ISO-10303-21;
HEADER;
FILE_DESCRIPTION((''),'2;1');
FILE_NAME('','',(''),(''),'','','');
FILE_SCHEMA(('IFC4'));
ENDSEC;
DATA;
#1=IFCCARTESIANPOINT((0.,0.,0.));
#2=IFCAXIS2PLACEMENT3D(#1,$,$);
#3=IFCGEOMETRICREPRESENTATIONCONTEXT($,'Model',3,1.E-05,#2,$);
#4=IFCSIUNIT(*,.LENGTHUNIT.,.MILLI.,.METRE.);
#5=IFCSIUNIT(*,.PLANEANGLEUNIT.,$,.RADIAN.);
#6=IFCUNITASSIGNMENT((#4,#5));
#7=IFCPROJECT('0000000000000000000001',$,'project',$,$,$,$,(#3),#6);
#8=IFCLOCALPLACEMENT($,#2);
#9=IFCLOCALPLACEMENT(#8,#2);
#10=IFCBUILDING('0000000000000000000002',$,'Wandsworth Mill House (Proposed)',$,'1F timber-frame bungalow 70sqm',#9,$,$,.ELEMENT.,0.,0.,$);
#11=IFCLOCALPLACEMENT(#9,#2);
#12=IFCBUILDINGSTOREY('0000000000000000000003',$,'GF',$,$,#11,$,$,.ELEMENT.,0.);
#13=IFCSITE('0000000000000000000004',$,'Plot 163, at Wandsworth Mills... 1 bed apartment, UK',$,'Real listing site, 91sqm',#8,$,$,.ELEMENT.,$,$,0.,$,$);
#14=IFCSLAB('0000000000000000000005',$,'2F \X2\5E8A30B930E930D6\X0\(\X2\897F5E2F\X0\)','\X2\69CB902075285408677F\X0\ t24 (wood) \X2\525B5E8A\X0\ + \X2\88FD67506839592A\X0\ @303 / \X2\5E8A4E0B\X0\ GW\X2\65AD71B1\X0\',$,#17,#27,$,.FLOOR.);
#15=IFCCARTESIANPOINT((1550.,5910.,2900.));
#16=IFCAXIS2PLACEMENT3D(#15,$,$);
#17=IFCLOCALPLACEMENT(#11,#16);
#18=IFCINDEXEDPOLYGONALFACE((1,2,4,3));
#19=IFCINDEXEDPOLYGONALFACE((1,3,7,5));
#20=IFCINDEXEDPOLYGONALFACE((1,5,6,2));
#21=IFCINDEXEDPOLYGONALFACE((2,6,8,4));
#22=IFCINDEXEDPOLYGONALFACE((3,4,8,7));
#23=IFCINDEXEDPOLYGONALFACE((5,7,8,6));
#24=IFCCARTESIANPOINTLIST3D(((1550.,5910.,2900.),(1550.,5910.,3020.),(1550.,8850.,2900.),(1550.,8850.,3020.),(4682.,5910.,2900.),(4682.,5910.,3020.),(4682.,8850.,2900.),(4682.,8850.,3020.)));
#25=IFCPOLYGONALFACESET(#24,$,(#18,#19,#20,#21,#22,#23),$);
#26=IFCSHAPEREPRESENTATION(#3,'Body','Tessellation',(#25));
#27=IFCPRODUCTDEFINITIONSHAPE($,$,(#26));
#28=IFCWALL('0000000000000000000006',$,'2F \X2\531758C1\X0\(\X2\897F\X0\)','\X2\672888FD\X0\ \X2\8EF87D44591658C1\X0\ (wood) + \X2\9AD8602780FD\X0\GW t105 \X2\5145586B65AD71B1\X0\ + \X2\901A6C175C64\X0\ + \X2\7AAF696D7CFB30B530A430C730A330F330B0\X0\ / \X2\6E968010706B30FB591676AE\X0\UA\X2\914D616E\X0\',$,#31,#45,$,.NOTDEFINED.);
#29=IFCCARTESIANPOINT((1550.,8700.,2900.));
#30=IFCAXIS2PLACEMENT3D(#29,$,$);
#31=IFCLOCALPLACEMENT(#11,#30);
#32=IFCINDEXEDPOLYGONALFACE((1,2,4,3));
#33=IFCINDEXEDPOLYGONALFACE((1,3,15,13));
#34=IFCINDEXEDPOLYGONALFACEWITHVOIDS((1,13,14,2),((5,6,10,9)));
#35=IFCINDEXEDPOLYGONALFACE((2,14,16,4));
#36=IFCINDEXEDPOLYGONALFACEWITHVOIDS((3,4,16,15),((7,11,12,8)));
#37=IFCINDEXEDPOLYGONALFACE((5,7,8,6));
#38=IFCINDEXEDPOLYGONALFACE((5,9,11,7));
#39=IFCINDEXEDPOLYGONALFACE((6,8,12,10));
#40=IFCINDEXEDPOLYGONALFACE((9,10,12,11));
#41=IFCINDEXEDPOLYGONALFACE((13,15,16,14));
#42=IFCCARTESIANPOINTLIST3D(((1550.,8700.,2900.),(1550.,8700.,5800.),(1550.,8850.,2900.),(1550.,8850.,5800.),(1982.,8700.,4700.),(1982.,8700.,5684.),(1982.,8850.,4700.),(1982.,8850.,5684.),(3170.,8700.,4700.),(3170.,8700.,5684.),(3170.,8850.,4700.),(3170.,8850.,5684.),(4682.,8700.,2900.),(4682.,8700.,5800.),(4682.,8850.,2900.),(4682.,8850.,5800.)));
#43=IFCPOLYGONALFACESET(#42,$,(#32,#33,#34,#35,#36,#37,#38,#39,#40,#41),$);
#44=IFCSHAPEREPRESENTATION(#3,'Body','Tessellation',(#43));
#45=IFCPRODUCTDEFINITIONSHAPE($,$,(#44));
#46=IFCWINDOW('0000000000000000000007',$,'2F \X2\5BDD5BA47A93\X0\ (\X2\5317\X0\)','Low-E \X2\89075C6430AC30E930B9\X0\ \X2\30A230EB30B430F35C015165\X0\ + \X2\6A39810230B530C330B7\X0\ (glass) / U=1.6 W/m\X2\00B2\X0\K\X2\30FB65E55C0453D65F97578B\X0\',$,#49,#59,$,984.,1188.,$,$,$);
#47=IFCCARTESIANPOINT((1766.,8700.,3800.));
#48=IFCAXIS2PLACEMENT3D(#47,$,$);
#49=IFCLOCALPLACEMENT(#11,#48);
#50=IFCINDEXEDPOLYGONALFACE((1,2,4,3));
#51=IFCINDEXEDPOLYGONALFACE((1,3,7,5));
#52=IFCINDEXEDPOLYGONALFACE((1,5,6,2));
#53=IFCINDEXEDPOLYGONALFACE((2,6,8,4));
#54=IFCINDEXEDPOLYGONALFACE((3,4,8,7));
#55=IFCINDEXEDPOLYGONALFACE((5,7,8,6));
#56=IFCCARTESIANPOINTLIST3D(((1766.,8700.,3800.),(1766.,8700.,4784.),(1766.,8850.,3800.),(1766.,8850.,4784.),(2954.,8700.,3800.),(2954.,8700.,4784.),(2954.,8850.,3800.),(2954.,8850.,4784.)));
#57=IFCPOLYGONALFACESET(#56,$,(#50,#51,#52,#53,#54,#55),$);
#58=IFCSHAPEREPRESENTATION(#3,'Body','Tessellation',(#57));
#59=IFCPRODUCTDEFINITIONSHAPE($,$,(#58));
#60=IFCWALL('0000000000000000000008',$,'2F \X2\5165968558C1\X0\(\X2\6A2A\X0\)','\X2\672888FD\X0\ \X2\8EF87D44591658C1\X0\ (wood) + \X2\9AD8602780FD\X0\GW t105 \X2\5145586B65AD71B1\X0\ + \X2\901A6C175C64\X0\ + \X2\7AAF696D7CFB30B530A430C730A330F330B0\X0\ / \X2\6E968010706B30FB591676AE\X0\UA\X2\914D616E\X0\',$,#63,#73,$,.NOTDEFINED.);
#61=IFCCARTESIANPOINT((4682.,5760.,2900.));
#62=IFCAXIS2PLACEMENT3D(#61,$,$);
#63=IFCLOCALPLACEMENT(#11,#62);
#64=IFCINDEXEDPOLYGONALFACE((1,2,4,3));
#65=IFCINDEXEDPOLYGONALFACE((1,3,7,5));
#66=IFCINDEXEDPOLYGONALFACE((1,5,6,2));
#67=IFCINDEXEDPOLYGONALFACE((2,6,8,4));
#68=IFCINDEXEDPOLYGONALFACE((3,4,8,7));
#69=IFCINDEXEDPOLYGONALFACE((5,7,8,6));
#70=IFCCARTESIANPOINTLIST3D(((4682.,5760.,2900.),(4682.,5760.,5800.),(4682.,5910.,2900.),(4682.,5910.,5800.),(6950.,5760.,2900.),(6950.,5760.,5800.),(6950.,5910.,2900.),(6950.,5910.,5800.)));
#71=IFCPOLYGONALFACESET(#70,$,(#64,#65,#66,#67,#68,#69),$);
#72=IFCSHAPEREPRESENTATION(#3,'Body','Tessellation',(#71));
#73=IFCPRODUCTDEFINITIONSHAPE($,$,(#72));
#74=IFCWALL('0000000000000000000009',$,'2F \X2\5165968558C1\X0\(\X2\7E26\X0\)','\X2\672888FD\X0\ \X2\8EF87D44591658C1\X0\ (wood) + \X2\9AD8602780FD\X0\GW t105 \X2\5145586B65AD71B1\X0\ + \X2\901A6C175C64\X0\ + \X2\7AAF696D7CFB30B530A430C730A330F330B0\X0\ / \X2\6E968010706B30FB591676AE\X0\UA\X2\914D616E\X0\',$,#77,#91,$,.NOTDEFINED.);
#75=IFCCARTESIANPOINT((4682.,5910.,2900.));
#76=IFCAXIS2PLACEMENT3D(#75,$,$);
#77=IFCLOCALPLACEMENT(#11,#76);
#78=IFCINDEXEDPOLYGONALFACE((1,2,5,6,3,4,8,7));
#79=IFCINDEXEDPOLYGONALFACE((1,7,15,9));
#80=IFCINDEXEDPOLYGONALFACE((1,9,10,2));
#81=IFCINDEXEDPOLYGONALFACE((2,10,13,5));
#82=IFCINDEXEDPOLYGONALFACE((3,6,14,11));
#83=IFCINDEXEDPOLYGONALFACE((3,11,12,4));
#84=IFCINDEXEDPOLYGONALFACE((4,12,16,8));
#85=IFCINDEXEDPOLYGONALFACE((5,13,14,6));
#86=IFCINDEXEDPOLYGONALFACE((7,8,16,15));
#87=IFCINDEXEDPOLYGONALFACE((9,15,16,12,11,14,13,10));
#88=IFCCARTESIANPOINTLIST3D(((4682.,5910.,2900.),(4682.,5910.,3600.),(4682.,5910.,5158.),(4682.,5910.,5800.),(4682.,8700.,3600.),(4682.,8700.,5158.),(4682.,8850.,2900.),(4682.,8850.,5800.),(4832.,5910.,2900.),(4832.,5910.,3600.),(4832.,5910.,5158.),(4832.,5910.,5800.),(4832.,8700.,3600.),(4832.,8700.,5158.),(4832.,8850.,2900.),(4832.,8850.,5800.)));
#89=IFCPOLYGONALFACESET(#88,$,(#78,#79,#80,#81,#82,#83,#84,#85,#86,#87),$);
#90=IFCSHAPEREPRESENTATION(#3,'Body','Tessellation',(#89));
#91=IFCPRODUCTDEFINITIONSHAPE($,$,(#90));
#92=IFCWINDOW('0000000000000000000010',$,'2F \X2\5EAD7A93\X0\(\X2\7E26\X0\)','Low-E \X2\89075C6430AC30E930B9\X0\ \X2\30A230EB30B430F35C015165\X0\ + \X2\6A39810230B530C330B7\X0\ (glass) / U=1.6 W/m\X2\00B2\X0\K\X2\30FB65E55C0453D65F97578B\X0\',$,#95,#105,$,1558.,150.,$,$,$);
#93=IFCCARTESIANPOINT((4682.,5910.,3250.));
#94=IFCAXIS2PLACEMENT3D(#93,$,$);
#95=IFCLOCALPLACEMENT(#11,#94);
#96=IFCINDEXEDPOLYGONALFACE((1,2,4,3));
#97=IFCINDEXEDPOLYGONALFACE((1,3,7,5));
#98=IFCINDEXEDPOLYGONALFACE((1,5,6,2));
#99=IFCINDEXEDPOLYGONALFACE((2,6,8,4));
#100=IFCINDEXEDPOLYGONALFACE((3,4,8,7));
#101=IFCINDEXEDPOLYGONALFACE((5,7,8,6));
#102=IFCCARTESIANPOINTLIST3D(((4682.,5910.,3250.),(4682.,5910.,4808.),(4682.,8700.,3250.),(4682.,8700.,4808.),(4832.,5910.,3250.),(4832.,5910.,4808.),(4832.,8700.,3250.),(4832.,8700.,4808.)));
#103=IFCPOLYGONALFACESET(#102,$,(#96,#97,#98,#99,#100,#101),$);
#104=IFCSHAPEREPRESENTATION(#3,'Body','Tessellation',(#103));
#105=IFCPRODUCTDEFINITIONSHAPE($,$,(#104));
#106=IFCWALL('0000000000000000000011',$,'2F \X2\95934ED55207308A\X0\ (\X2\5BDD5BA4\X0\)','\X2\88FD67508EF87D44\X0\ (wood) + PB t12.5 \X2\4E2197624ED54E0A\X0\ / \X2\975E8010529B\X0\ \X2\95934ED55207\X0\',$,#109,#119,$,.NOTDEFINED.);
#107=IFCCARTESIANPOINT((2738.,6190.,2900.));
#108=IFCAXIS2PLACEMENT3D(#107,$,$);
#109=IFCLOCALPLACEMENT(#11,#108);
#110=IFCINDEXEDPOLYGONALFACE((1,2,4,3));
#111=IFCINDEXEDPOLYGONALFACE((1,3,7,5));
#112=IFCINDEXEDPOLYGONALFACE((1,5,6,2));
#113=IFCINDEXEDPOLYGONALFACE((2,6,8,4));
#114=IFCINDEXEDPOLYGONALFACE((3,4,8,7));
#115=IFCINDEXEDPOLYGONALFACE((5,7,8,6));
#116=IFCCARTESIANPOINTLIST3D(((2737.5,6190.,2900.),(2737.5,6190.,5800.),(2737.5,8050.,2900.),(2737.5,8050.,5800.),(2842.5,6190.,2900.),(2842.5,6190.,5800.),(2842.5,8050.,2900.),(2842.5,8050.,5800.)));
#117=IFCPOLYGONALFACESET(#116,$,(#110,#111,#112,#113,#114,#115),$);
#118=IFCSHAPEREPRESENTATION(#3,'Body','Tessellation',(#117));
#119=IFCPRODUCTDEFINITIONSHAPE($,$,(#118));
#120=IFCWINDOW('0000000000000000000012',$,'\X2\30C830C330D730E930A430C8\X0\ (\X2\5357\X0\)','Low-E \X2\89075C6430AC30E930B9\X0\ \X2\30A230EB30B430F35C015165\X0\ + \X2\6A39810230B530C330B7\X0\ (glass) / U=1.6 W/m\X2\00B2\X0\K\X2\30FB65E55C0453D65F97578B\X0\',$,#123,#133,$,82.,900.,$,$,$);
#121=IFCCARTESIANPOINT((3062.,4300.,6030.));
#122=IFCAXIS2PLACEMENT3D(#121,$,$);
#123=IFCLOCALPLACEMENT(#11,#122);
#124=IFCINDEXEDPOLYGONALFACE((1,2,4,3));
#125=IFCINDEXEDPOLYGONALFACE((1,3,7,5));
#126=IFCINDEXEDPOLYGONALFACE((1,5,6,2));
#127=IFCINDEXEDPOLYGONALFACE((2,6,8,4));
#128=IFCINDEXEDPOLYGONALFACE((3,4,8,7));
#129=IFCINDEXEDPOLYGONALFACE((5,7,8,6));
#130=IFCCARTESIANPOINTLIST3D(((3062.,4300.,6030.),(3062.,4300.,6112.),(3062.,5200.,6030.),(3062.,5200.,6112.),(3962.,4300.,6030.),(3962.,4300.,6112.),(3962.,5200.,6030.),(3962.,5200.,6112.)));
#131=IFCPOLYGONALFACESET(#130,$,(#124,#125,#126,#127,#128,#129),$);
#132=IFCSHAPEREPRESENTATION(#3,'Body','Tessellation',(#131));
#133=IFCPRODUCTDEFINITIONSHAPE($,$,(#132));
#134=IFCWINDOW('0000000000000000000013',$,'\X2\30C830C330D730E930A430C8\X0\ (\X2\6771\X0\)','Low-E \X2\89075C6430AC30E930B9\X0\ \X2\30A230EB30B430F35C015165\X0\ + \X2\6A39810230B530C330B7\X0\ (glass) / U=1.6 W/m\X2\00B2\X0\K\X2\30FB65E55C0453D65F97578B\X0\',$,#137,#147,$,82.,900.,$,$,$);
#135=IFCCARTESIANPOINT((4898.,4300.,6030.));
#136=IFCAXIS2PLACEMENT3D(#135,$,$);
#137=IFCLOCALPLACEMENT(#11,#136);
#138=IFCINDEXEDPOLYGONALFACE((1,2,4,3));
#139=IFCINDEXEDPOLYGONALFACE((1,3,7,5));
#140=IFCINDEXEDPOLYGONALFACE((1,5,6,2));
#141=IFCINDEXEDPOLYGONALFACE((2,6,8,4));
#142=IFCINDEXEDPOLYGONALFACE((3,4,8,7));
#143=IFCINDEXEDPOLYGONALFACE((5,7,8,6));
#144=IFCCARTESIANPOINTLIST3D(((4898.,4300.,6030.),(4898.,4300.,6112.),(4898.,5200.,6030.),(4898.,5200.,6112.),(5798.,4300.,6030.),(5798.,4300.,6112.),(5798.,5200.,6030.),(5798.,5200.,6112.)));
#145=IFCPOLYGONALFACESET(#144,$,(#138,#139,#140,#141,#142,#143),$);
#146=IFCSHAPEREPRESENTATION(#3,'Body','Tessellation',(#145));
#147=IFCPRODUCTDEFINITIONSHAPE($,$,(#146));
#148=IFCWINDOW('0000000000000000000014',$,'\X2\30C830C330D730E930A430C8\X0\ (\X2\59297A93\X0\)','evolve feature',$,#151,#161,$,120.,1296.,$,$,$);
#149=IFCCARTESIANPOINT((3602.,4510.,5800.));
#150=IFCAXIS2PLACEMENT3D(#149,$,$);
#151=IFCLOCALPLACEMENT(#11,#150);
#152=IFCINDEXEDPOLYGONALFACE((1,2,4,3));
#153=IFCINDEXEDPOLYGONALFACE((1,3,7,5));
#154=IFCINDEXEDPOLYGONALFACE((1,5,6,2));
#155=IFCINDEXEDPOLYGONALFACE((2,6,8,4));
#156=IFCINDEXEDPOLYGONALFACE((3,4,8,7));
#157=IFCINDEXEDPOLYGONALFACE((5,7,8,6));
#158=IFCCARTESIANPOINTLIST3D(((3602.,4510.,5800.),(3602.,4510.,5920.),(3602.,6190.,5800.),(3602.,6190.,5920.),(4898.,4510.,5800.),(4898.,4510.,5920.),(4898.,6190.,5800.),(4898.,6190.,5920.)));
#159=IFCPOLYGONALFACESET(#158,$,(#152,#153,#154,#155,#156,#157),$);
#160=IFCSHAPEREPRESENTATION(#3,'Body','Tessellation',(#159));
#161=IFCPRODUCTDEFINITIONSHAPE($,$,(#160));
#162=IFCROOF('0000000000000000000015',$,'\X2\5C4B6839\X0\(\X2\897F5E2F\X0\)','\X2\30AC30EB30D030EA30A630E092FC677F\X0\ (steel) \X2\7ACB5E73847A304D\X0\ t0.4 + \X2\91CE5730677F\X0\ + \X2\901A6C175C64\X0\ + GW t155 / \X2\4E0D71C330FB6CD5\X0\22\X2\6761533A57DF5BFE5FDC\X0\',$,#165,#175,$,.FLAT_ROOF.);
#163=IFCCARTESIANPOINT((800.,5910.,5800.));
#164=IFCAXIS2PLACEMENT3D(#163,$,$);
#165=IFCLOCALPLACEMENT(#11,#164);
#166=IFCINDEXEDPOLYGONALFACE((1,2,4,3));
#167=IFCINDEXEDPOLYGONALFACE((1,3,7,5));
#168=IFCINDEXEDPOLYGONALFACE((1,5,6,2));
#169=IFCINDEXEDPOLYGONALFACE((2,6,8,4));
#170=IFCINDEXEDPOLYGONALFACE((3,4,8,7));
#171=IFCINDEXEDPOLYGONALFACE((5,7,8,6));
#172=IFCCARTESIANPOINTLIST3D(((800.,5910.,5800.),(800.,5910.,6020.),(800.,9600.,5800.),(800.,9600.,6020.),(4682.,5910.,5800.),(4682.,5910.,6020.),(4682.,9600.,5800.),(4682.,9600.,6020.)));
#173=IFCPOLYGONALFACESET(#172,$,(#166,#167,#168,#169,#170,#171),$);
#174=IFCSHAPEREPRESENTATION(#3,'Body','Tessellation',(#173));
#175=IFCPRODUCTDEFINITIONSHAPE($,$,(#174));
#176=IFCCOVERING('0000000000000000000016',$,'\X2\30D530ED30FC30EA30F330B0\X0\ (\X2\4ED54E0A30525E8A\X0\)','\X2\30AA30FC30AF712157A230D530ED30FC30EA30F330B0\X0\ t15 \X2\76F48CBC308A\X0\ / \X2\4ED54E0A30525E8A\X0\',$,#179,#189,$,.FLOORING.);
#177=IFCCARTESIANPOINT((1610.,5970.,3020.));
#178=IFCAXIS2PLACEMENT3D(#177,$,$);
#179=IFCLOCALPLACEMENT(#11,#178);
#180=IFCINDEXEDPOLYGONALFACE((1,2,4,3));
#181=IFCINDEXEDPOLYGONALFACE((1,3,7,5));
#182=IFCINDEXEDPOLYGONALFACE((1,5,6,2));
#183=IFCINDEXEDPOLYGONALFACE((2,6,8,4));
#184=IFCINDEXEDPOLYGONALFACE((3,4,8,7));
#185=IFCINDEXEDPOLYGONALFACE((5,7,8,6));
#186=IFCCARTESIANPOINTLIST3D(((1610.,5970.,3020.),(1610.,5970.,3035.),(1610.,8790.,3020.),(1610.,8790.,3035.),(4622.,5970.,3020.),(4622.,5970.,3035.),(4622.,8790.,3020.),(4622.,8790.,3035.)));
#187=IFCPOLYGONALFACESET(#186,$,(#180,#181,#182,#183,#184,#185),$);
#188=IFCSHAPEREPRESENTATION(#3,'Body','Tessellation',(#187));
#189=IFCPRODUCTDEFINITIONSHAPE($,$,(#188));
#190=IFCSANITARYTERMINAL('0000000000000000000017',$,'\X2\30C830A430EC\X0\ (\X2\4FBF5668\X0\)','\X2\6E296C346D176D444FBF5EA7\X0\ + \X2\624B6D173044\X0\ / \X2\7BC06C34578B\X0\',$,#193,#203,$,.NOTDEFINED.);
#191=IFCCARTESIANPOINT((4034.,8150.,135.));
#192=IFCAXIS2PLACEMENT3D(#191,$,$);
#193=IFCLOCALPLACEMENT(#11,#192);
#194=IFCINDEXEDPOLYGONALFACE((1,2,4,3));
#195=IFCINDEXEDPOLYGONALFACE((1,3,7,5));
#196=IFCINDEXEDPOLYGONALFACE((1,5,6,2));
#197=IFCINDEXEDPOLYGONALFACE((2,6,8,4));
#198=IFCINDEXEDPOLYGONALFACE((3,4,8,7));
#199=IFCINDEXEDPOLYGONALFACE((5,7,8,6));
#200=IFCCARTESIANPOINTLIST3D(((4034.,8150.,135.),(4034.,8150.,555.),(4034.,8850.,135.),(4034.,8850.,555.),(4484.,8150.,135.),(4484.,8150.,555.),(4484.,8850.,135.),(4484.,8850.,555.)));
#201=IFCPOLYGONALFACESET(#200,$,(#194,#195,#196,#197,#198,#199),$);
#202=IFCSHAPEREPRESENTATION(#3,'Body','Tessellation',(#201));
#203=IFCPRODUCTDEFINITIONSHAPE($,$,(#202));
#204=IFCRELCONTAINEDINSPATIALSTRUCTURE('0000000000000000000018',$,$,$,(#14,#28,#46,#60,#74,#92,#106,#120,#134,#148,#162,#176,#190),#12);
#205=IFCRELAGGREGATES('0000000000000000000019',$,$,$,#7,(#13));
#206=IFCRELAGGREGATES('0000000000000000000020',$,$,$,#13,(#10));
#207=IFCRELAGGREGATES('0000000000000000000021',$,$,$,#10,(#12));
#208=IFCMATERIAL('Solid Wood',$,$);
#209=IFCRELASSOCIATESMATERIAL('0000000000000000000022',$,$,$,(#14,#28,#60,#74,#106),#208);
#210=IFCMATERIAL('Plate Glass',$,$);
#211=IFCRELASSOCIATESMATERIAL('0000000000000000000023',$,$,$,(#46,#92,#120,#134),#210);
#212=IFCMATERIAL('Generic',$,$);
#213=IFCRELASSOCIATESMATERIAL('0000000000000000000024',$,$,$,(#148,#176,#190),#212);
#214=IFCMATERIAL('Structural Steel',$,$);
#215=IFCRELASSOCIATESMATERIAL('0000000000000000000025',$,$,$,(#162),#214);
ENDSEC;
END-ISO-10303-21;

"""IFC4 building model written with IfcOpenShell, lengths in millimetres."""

from ifc_helpers import new_model, si_unit, frame, frame_2d, origin, place, context, project, spatial, rectangle, extrude, material, element, fill, save


model = new_model("IFC4")

# Units and contexts
model_context = context("Model", 3, precision=1e-05, world=origin())
ifc_project = project(units=[si_unit("LENGTHUNIT", "METRE", prefix="MILLI"), si_unit("PLANEANGLEUNIT", "RADIAN")], contexts=[model_context])

# Site, building, storey
site_placement = place(None, origin())
site = spatial("IfcSite", under=ifc_project, at=site_placement, Name="Plot 163, at Wandsworth Mills... 1 bed apartment, UK", ObjectType="Real listing site, 91sqm", CompositionType="ELEMENT", RefElevation=0.0)
building_placement = place(site_placement, origin())
building = spatial("IfcBuilding", under=site, at=building_placement, Name="Wandsworth Mill House (Proposed)", ObjectType="1F timber-frame bungalow 70sqm", CompositionType="ELEMENT", ElevationOfRefHeight=0.0, ElevationOfTerrain=0.0)
storey_placement = place(building_placement, origin())
storey = spatial("IfcBuildingStorey", under=building, at=storey_placement, Name="GF", CompositionType="ELEMENT", Elevation=0.0)

# Slab
ifc_material_1 = material(Name="Solid Wood")
slab_placement = place(storey_placement, frame((1550.0, 5910.0, 2900.0)))
element("IfcSlab", 1, at=slab_placement, inside=storey, material=ifc_material_1, Name="2F 床スラブ(西帯)", Description="構造用合板 t24 (wood) 剛床 + 製材根太 @303 / 床下 GW断熱", PredefinedType="FLOOR", context=model_context, shape_type="SweptSolid", body=[
    extrude(rectangle(XDim=3132.0, YDim=2940.0, at=frame_2d((1566.0, 1470.0))), frame((1550.0, 5910.0, 2900.0)), (0.0, 0.0, 1.0), 120.0),
])

# Wall, opening, window
wall_1_placement = place(storey_placement, frame((1550.0, 8700.0, 2900.0)))
wall_1 = element("IfcWall", 2, at=wall_1_placement, inside=storey, material=ifc_material_1, Name="2F 北壁(西)", Description="木製 軸組外壁 (wood) + 高性能GW t105 充填断熱 + 通気層 + 窯業系サイディング / 準耐火・外皮UA配慮", PredefinedType="NOTDEFINED", context=model_context, shape_type="SweptSolid", body=[
    extrude(rectangle(XDim=3132.0, YDim=150.0, at=frame_2d((1566.0, 75.0))), frame((1550.0, 8700.0, 2900.0)), (0.0, 0.0, 1.0), 2900.0),
])
opening_1_placement = place(storey_placement, frame((1766.0, 8700.0, 3800.0)))
opening_1 = element("IfcOpeningElement", 3, at=opening_1_placement, cuts=wall_1, PredefinedType="NOTDEFINED", context=model_context, shape_type="SweptSolid", body=[
    extrude(rectangle(XDim=1188.0, YDim=150.0, at=frame_2d((594.0, 75.0))), frame((1766.0, 8700.0, 3800.0)), (0.0, 0.0, 1.0), 984.0),
])
ifc_material_2 = material(Name="Plate Glass")
window_1_placement = place(storey_placement, frame((1766.0, 8700.0, 3800.0)))
window_1 = element("IfcWindow", 4, at=window_1_placement, inside=storey, material=ifc_material_2, Name="2F 寝室窓 (北)", Description="Low-E 複層ガラス アルゴン封入 + 樹脂サッシ (glass) / U=1.6 W/m²K・日射取得型", OverallHeight=984.0, OverallWidth=1188.0, context=model_context, shape_type="SweptSolid", body=[
    extrude(rectangle(XDim=1188.0, YDim=150.0, at=frame_2d((594.0, 75.0))), frame((1766.0, 8700.0, 3800.0)), (0.0, 0.0, 1.0), 984.0),
])
fill(opening_1, window_1)

# Wall
wall_2_placement = place(storey_placement, frame((4682.0, 5760.0, 2900.0)))
element("IfcWall", 5, at=wall_2_placement, inside=storey, material=ifc_material_1, Name="2F 入隅壁(横)", Description="木製 軸組外壁 (wood) + 高性能GW t105 充填断熱 + 通気層 + 窯業系サイディング / 準耐火・外皮UA配慮", PredefinedType="NOTDEFINED", context=model_context, shape_type="SweptSolid", body=[
    extrude(rectangle(XDim=2268.0, YDim=150.0, at=frame_2d((1134.0, 75.0))), frame((4682.0, 5760.0, 2900.0)), (0.0, 0.0, 1.0), 2900.0),
])

# Wall, opening, window
wall_3_placement = place(storey_placement, frame((4682.0, 5910.0, 2900.0)))
wall_3 = element("IfcWall", 6, at=wall_3_placement, inside=storey, material=ifc_material_1, Name="2F 入隅壁(縦)", Description="木製 軸組外壁 (wood) + 高性能GW t105 充填断熱 + 通気層 + 窯業系サイディング / 準耐火・外皮UA配慮", PredefinedType="NOTDEFINED", context=model_context, shape_type="SweptSolid", body=[
    extrude(rectangle(XDim=150.0, YDim=2940.0, at=frame_2d((75.0, 1470.0))), frame((4682.0, 5910.0, 2900.0)), (0.0, 0.0, 1.0), 2900.0),
])
opening_2_placement = place(storey_placement, frame((4682.0, 5910.0, 3250.0)))
opening_2 = element("IfcOpeningElement", 7, at=opening_2_placement, cuts=wall_3, PredefinedType="NOTDEFINED", context=model_context, shape_type="SweptSolid", body=[
    extrude(rectangle(XDim=150.0, YDim=2790.0, at=frame_2d((75.0, 1395.0))), frame((4682.0, 5910.0, 3250.0)), (0.0, 0.0, 1.0), 1558.0),
])
window_2_placement = place(storey_placement, frame((4682.0, 5910.0, 3250.0)))
window_2 = element("IfcWindow", 8, at=window_2_placement, inside=storey, material=ifc_material_2, Name="2F 庭窓(縦)", Description="Low-E 複層ガラス アルゴン封入 + 樹脂サッシ (glass) / U=1.6 W/m²K・日射取得型", OverallHeight=1558.0, OverallWidth=150.0, context=model_context, shape_type="SweptSolid", body=[
    extrude(rectangle(XDim=150.0, YDim=2790.0, at=frame_2d((75.0, 1395.0))), frame((4682.0, 5910.0, 3250.0)), (0.0, 0.0, 1.0), 1558.0),
])
fill(opening_2, window_2)

# Wall
wall_4_placement = place(storey_placement, frame((2738.0, 6190.0, 2900.0)))
element("IfcWall", 9, at=wall_4_placement, inside=storey, material=ifc_material_1, Name="2F 間仕切り (寝室)", Description="製材軸組 (wood) + PB t12.5 両面仕上 / 非耐力 間仕切", PredefinedType="NOTDEFINED", context=model_context, shape_type="SweptSolid", body=[
    extrude(rectangle(XDim=105.0, YDim=1860.0, at=frame_2d((52.0, 930.0))), frame((2738.0, 6190.0, 2900.0)), (0.0, 0.0, 1.0), 2900.0),
])

# Windows
window_3_placement = place(storey_placement, frame((3062.0, 4300.0, 6030.0)))
element("IfcWindow", 10, at=window_3_placement, inside=storey, material=ifc_material_2, Name="トップライト (南)", Description="Low-E 複層ガラス アルゴン封入 + 樹脂サッシ (glass) / U=1.6 W/m²K・日射取得型", OverallHeight=82.0, OverallWidth=900.0, context=model_context, shape_type="SweptSolid", body=[
    extrude(rectangle(XDim=900.0, YDim=900.0, at=frame_2d((450.0, 450.0))), frame((3062.0, 4300.0, 6030.0)), (0.0, 0.0, 1.0), 82.0),
])
window_4_placement = place(storey_placement, frame((4898.0, 4300.0, 6030.0)))
element("IfcWindow", 11, at=window_4_placement, inside=storey, material=ifc_material_2, Name="トップライト (東)", Description="Low-E 複層ガラス アルゴン封入 + 樹脂サッシ (glass) / U=1.6 W/m²K・日射取得型", OverallHeight=82.0, OverallWidth=900.0, context=model_context, shape_type="SweptSolid", body=[
    extrude(rectangle(XDim=900.0, YDim=900.0, at=frame_2d((450.0, 450.0))), frame((4898.0, 4300.0, 6030.0)), (0.0, 0.0, 1.0), 82.0),
])
ifc_material_3 = material(Name="Generic")
window_5_placement = place(storey_placement, frame((3602.0, 4510.0, 5800.0)))
element("IfcWindow", 12, at=window_5_placement, inside=storey, material=ifc_material_3, Name="トップライト (天窓)", Description="evolve feature", OverallHeight=120.0, OverallWidth=1296.0, context=model_context, shape_type="SweptSolid", body=[
    extrude(rectangle(XDim=1296.0, YDim=1680.0, at=frame_2d((648.0, 840.0))), frame((3602.0, 4510.0, 5800.0)), (0.0, 0.0, 1.0), 120.0),
])

# Roof
ifc_material_4 = material(Name="Structural Steel")
for number, where, name in (
    (13, (800.0, 5910.0, 5800.0), "屋根(西帯)"),
):
    element("IfcRoof", number, at=place(storey_placement, frame(where)), inside=storey, material=ifc_material_4, Name=name, Description="ガルバリウム鋼板 (steel) 立平葺き t0.4 + 野地板 + 通気層 + GW t155 / 不燃・法22条区域対応", PredefinedType="FLAT_ROOF", context=model_context, shape_type="SweptSolid", body=[
        extrude(rectangle(XDim=3882.0, YDim=3690.0, at=frame_2d((1941.0, 1845.0))), frame((800.0, 5910.0, 5800.0)), (0.0, 0.0, 1.0), 220.0),
    ])

# Covering
covering_placement = place(storey_placement, frame((1610.0, 5970.0, 3020.0)))
element("IfcCovering", 14, at=covering_placement, inside=storey, material=ifc_material_3, Name="フローリング (仕上げ床)", Description="オーク無垢フローリング t15 直貼り / 仕上げ床", PredefinedType="FLOORING", context=model_context, shape_type="SweptSolid", body=[
    extrude(rectangle(XDim=3012.0, YDim=2820.0, at=frame_2d((1506.0, 1410.0))), frame((1610.0, 5970.0, 3020.0)), (0.0, 0.0, 1.0), 15.0),
])

# Sanitary terminal
sanitary_terminal_placement = place(storey_placement, frame((4034.0, 8150.0, 135.0)))
element("IfcSanitaryTerminal", 15, at=sanitary_terminal_placement, inside=storey, material=ifc_material_3, Name="トイレ (便器)", Description="温水洗浄便座 + 手洗い / 節水型", PredefinedType="NOTDEFINED", context=model_context, shape_type="SweptSolid", body=[
    extrude(rectangle(XDim=450.0, YDim=700.0, at=frame_2d((225.0, 350.0))), frame((4034.0, 8150.0, 135.0)), (0.0, 0.0, 1.0), 420.0),
])

save(model, "model.ifc")
